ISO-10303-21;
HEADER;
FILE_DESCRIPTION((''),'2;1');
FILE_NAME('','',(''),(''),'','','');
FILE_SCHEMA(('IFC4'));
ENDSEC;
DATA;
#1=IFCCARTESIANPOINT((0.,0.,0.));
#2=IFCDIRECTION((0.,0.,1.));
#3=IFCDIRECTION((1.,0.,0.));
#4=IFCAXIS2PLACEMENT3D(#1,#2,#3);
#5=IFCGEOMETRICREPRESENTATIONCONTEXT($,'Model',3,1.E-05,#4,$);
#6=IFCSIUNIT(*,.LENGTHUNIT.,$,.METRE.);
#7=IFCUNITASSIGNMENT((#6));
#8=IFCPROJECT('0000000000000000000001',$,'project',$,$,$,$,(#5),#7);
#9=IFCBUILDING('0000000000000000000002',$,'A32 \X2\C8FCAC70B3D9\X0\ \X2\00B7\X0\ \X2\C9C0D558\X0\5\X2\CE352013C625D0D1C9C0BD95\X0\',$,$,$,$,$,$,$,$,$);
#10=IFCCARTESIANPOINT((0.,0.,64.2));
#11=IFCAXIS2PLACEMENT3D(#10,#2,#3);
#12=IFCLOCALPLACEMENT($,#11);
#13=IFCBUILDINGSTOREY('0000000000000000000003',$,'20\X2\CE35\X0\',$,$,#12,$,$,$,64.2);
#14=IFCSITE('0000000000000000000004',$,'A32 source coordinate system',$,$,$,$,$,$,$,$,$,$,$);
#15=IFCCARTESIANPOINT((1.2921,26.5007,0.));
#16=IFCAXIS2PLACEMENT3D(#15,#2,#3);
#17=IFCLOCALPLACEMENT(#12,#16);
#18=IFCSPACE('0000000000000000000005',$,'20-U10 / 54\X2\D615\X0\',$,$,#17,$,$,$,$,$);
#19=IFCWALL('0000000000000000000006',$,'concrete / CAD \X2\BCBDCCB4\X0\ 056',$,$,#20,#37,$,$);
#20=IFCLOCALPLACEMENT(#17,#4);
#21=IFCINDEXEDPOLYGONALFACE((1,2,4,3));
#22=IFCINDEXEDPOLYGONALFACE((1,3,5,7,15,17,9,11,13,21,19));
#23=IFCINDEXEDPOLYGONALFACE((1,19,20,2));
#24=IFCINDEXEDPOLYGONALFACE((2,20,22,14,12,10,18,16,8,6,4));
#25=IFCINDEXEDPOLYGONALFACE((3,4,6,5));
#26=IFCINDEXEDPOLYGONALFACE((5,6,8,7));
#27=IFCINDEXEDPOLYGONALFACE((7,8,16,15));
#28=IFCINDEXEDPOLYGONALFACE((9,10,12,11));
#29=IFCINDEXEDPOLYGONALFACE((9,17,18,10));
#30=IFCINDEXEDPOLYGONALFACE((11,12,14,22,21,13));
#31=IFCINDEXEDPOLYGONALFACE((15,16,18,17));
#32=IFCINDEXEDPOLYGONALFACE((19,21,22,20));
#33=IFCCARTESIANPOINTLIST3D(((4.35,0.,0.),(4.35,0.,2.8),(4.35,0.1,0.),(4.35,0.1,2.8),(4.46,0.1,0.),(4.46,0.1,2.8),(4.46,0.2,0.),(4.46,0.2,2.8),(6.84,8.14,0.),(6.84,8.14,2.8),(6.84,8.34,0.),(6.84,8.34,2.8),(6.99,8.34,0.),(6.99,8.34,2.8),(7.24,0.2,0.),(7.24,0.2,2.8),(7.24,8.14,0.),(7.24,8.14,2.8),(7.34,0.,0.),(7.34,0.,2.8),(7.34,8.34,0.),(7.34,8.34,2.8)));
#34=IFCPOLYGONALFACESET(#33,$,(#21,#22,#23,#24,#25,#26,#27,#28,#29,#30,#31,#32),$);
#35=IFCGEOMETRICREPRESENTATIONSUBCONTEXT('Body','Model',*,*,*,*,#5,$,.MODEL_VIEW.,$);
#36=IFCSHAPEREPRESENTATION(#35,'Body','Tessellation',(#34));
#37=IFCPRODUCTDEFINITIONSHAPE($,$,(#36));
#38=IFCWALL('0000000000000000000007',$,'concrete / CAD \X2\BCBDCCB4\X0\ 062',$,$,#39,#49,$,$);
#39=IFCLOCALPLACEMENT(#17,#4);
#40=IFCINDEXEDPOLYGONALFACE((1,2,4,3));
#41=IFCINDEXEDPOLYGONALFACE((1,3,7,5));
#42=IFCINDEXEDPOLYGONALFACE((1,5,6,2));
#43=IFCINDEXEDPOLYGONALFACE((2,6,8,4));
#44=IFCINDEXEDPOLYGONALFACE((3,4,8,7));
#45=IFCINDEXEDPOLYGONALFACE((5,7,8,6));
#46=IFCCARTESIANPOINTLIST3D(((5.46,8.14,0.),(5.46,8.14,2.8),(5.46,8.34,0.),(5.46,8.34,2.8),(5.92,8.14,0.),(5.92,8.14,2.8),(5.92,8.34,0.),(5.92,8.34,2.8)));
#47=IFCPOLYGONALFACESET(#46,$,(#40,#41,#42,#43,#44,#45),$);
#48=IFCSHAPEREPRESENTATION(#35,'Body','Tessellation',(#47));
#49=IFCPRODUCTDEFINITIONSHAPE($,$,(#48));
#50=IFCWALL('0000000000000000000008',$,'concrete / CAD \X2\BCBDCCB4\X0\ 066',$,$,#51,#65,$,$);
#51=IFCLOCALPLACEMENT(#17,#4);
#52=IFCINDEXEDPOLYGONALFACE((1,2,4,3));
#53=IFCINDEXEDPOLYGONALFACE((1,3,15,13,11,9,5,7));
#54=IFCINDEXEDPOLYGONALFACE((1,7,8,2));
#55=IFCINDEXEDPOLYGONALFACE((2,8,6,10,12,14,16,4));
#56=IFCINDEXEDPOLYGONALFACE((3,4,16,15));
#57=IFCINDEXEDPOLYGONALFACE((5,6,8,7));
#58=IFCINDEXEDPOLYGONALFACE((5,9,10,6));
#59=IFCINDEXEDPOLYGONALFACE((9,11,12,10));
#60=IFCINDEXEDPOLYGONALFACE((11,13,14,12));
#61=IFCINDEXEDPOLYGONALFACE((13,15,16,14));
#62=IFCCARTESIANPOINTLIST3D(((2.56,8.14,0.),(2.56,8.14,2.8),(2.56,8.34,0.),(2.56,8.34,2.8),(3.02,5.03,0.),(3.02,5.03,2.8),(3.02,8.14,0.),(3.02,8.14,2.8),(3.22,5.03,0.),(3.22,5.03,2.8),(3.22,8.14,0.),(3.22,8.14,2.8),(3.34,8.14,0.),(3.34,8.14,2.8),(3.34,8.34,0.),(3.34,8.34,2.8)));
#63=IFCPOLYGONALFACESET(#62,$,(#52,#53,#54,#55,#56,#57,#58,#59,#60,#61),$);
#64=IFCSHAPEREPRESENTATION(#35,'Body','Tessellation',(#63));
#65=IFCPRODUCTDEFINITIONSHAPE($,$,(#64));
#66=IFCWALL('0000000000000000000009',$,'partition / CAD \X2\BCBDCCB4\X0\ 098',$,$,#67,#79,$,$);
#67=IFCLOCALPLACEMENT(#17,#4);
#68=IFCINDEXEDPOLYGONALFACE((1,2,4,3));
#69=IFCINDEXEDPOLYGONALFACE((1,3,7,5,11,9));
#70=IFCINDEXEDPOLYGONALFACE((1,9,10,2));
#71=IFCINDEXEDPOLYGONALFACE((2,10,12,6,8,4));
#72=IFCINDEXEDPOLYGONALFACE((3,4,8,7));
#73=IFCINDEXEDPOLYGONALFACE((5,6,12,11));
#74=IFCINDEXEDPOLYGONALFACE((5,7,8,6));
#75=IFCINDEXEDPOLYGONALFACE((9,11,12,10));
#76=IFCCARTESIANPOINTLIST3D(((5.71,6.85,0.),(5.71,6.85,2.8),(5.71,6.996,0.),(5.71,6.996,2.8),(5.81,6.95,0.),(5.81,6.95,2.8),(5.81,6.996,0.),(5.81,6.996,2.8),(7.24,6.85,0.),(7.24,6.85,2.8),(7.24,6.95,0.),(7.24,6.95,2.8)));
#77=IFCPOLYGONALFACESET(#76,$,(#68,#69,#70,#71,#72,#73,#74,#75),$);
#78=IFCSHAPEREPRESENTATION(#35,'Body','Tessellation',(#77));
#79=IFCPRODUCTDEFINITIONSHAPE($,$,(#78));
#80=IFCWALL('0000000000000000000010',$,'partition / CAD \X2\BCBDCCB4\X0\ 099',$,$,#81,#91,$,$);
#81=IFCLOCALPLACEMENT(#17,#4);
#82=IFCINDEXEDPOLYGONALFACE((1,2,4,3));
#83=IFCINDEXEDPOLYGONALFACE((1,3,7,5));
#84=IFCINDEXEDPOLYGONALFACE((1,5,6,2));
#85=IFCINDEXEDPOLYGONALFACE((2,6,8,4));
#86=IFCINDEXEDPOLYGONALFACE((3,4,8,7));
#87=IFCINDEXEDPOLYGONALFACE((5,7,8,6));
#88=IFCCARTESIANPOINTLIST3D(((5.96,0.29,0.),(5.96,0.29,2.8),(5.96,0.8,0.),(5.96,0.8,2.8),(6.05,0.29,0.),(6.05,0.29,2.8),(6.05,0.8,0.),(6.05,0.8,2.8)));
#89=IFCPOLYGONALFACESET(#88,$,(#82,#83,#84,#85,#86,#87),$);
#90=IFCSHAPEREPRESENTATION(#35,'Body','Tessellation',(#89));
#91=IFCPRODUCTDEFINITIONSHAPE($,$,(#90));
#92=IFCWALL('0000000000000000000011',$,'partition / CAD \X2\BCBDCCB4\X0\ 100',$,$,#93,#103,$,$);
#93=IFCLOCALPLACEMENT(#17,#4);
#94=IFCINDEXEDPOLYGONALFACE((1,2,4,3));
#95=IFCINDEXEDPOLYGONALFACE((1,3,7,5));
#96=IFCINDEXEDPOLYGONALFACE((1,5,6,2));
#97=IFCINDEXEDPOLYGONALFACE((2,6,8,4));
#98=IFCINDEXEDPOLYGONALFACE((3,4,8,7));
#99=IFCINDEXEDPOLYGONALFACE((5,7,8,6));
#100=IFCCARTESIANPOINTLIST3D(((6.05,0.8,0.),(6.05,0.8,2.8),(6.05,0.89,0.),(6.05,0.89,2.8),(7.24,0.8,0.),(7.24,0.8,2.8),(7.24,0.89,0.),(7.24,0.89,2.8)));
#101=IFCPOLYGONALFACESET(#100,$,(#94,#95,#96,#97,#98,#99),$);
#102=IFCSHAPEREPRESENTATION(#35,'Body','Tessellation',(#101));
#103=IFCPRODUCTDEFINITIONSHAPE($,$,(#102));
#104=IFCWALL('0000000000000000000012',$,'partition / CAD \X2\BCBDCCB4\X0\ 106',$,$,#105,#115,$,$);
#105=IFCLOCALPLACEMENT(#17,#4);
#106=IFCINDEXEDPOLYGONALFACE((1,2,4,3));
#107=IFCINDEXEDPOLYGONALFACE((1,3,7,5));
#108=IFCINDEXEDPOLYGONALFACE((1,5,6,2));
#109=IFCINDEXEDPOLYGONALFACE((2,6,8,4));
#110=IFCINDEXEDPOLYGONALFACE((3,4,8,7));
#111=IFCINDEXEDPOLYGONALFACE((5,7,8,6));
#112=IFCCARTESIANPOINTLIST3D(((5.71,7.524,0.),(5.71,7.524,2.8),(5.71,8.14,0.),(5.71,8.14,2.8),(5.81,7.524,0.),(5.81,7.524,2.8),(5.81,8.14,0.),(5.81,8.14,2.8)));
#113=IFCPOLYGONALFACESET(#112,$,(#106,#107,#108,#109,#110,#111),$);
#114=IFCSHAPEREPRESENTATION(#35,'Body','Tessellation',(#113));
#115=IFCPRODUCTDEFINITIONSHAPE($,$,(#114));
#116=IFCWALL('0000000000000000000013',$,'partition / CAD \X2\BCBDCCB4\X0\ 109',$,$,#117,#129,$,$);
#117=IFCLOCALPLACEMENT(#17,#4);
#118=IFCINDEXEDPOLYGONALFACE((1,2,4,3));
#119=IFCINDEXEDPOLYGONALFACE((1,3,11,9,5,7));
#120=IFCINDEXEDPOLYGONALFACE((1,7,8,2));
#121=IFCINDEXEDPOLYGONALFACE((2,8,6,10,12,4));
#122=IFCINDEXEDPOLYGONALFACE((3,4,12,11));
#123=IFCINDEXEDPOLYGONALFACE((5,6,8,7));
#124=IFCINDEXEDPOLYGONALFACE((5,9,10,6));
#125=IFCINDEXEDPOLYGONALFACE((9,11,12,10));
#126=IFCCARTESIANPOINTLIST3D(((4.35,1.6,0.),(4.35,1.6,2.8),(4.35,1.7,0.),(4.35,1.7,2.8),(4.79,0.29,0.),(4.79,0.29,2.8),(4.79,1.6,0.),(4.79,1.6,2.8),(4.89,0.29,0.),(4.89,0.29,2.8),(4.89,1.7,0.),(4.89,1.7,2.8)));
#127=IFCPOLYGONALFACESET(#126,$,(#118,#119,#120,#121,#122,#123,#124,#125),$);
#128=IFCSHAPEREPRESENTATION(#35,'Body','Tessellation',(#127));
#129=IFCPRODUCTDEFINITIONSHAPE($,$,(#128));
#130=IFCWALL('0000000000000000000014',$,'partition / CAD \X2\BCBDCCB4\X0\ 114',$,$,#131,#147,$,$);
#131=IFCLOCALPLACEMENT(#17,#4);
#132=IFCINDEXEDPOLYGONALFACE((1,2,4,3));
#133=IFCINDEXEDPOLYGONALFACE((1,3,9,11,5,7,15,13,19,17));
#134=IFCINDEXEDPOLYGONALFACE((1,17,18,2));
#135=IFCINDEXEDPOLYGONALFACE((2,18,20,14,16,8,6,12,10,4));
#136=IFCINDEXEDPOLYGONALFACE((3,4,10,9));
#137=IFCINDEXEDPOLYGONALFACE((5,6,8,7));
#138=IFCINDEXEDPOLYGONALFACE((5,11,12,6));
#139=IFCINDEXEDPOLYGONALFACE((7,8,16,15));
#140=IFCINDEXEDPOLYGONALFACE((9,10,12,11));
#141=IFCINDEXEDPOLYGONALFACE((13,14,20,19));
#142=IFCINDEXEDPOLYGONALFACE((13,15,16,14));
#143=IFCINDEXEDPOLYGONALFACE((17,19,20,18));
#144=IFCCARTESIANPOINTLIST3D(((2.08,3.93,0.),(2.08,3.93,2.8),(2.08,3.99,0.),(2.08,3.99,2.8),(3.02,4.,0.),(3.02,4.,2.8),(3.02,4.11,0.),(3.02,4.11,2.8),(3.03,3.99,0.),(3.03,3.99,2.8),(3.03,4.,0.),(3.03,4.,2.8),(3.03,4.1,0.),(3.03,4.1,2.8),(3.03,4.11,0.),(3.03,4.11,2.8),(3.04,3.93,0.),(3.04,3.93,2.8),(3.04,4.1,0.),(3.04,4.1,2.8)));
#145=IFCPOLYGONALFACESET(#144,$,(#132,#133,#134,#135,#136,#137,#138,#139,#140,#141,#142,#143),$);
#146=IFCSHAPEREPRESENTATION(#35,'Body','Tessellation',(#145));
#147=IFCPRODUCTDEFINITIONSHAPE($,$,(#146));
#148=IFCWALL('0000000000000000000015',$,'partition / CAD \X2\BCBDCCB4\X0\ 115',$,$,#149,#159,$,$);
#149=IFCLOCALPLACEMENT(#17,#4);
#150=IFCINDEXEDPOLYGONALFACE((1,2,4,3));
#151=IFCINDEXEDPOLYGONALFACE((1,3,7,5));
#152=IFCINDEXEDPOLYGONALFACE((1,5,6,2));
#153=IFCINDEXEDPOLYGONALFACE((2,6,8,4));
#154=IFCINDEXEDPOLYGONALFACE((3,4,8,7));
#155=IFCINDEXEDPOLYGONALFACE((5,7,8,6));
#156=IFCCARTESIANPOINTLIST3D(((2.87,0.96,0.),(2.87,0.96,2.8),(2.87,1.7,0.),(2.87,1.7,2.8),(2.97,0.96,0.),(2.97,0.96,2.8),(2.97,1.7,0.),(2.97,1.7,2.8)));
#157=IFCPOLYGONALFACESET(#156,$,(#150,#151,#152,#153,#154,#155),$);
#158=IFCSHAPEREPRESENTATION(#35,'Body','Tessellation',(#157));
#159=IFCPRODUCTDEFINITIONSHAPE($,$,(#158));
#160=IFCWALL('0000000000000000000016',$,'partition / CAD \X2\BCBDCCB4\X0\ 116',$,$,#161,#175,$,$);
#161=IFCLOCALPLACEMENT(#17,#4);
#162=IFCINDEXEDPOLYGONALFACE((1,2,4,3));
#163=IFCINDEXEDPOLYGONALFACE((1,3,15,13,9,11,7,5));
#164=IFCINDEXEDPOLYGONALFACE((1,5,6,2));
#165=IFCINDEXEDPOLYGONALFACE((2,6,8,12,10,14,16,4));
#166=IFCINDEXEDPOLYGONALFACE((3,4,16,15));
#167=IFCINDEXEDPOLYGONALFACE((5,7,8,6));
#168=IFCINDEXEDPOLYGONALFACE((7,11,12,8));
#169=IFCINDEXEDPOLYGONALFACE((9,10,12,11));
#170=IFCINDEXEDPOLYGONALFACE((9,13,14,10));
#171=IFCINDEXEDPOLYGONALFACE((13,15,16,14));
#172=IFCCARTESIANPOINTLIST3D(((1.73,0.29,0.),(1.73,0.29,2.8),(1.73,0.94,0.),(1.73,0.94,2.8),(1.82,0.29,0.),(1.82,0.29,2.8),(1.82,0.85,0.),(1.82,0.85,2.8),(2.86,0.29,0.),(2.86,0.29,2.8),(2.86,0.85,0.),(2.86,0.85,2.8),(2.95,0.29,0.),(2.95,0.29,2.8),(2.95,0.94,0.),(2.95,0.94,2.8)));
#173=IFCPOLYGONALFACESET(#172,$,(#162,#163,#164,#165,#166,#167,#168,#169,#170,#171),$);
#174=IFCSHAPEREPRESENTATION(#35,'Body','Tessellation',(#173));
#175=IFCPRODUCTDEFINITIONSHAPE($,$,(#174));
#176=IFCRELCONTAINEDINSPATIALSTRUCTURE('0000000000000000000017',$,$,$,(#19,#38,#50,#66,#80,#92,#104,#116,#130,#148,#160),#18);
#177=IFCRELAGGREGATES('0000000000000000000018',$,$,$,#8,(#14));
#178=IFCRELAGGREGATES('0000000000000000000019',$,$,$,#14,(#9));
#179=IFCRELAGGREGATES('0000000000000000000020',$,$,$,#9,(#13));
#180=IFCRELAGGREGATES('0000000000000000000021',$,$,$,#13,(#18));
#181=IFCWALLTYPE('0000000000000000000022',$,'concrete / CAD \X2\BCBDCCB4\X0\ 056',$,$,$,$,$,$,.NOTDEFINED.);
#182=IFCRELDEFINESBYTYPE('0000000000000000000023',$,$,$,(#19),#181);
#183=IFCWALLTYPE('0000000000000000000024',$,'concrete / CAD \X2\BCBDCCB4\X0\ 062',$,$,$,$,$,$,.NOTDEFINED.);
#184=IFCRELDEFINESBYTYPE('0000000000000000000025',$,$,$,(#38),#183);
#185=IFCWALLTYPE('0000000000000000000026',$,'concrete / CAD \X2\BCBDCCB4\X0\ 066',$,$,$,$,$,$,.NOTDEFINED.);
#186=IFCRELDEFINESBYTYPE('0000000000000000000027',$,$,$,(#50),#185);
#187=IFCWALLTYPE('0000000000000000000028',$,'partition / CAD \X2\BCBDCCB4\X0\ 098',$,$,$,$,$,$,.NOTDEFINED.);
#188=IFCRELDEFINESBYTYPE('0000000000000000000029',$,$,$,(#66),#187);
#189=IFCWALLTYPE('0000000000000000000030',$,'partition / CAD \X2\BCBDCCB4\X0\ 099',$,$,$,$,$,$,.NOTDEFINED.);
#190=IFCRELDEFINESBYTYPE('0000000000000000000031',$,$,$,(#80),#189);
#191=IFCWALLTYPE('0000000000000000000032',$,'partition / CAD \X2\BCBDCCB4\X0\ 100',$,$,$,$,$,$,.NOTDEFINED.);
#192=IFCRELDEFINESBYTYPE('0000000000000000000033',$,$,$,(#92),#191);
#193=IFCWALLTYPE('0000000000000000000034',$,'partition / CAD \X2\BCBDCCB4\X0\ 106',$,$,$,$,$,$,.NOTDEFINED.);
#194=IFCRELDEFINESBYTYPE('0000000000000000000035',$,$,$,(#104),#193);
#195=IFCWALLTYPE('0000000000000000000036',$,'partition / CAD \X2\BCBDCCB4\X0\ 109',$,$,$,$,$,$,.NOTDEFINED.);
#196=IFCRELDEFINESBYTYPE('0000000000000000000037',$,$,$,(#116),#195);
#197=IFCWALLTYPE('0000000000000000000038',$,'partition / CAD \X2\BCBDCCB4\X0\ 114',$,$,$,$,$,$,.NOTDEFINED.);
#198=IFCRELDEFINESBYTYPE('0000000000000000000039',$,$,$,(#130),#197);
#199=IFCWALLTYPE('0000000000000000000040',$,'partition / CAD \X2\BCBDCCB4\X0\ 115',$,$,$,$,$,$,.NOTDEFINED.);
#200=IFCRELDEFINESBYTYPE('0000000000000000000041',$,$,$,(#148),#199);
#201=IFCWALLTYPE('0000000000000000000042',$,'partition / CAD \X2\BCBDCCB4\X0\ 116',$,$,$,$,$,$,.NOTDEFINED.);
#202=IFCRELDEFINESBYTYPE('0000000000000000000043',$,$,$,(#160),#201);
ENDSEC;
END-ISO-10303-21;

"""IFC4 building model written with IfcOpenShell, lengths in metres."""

from ifc_helpers import new_model, si_unit, frame, origin, origin_with_axes, place, context, subcontext, project, spatial, polyline, outline, extrude, source, transform, mapped, type_object, type_shapes, element, save


model = new_model("IFC4")

# Units and contexts
model_context = context("Model", 3, precision=1e-05, world=origin_with_axes())
body_context = subcontext(model_context, "Body", "Model", "MODEL_VIEW")
ifc_project = project(units=[si_unit("LENGTHUNIT", "METRE")], contexts=[model_context])

# Site, building, storey, space
site = spatial("IfcSite", under=ifc_project, Name="A32 source coordinate system")
building = spatial("IfcBuilding", under=site, Name="A32 주거동 · 지하5층–옥탑지붕")
storey_placement = place(None, frame((0.0, 0.0, 64.2), z_axis=(0.0, 0.0, 1.0), x_axis=(1.0, 0.0, 0.0)))
storey = spatial("IfcBuildingStorey", under=building, at=storey_placement, Name="20층", Elevation=64.2)
space_placement = place(storey_placement, frame((1.2921, 26.5007, 0.0), z_axis=(0.0, 0.0, 1.0), x_axis=(1.0, 0.0, 0.0)))
space = spatial("IfcSpace", under=storey, at=space_placement, Name="20-U10 / 54형")

# Walls
wall_type_1 = type_object("IfcWallType", Name="concrete / CAD 벽체 056", PredefinedType="NOTDEFINED")
shared_shape_1 = source(origin(), body_context, "Body", "SweptSolid", [
    extrude(outline(polyline([(7.24, 0.2), (7.24, 8.14), (6.84, 8.14), (6.84, 8.34), (6.99, 8.34), (6.99, 8.34), (7.34, 8.34), (7.34, 0.0), (4.35, 0.0), (4.35, 0.1), (4.46, 0.1), (4.46, 0.2), (7.24, 0.2)])), origin(), (0.0, 0.0, 1.0), 2.8),
])
type_shapes(wall_type_1, [shared_shape_1])
wall_1_placement = place(space_placement, origin_with_axes())
element("IfcWall", 1, at=wall_1_placement, inside=space, type_object=wall_type_1, Name="concrete / CAD 벽체 056", context=body_context, shape_type="MappedRepresentation", body=[
    mapped(shared_shape_1, transform((0.0, 0.0, 0.0), scale=1.0)),
])
wall_type_2 = type_object("IfcWallType", Name="concrete / CAD 벽체 062", PredefinedType="NOTDEFINED")
shared_shape_2 = source(origin(), body_context, "Body", "SweptSolid", [
    extrude(outline(polyline([(5.46, 8.14), (5.46, 8.34), (5.92, 8.34), (5.92, 8.14), (5.46, 8.14)])), origin(), (0.0, 0.0, 1.0), 2.8),
])
type_shapes(wall_type_2, [shared_shape_2])
wall_2_placement = place(space_placement, origin_with_axes())
element("IfcWall", 2, at=wall_2_placement, inside=space, type_object=wall_type_2, Name="concrete / CAD 벽체 062", context=body_context, shape_type="MappedRepresentation", body=[
    mapped(shared_shape_2, transform((0.0, 0.0, 0.0), scale=1.0)),
])
wall_type_3 = type_object("IfcWallType", Name="concrete / CAD 벽체 066", PredefinedType="NOTDEFINED")
shared_shape_3 = source(origin(), body_context, "Body", "SweptSolid", [
    extrude(outline(polyline([(3.22, 8.14), (3.22, 5.03), (3.02, 5.03), (3.02, 8.14), (2.56, 8.14), (2.56, 8.34), (3.34, 8.34), (3.34, 8.14), (3.22, 8.14)])), origin(), (0.0, 0.0, 1.0), 2.8),
])
type_shapes(wall_type_3, [shared_shape_3])
wall_3_placement = place(space_placement, origin_with_axes())
element("IfcWall", 3, at=wall_3_placement, inside=space, type_object=wall_type_3, Name="concrete / CAD 벽체 066", context=body_context, shape_type="MappedRepresentation", body=[
    mapped(shared_shape_3, transform((0.0, 0.0, 0.0), scale=1.0)),
])
wall_type_4 = type_object("IfcWallType", Name="partition / CAD 벽체 098", PredefinedType="NOTDEFINED")
shared_shape_4 = source(origin(), body_context, "Body", "SweptSolid", [
    extrude(outline(polyline([(5.71, 6.996), (5.81, 6.996), (5.81, 6.95), (7.24, 6.95), (7.24, 6.85), (5.71, 6.85), (5.71, 6.996)])), origin(), (0.0, 0.0, 1.0), 2.8),
])
type_shapes(wall_type_4, [shared_shape_4])
wall_4_placement = place(space_placement, origin_with_axes())
element("IfcWall", 4, at=wall_4_placement, inside=space, type_object=wall_type_4, Name="partition / CAD 벽체 098", context=body_context, shape_type="MappedRepresentation", body=[
    mapped(shared_shape_4, transform((0.0, 0.0, 0.0), scale=1.0)),
])
wall_type_5 = type_object("IfcWallType", Name="partition / CAD 벽체 099", PredefinedType="NOTDEFINED")
shared_shape_5 = source(origin(), body_context, "Body", "SweptSolid", [
    extrude(outline(polyline([(6.05, 0.8), (6.05, 0.29), (5.96, 0.29), (5.96, 0.8), (6.05, 0.8)])), origin(), (0.0, 0.0, 1.0), 2.8),
])
type_shapes(wall_type_5, [shared_shape_5])
wall_5_placement = place(space_placement, origin_with_axes())
element("IfcWall", 5, at=wall_5_placement, inside=space, type_object=wall_type_5, Name="partition / CAD 벽체 099", context=body_context, shape_type="MappedRepresentation", body=[
    mapped(shared_shape_5, transform((0.0, 0.0, 0.0), scale=1.0)),
])
wall_type_6 = type_object("IfcWallType", Name="partition / CAD 벽체 100", PredefinedType="NOTDEFINED")
shared_shape_6 = source(origin(), body_context, "Body", "SweptSolid", [
    extrude(outline(polyline([(7.24, 0.8), (6.05, 0.8), (6.05, 0.89), (7.24, 0.89), (7.24, 0.8)])), origin(), (0.0, 0.0, 1.0), 2.8),
])
type_shapes(wall_type_6, [shared_shape_6])
wall_6_placement = place(space_placement, origin_with_axes())
element("IfcWall", 6, at=wall_6_placement, inside=space, type_object=wall_type_6, Name="partition / CAD 벽체 100", context=body_context, shape_type="MappedRepresentation", body=[
    mapped(shared_shape_6, transform((0.0, 0.0, 0.0), scale=1.0)),
])
wall_type_7 = type_object("IfcWallType", Name="partition / CAD 벽체 106", PredefinedType="NOTDEFINED")
shared_shape_7 = source(origin(), body_context, "Body", "SweptSolid", [
    extrude(outline(polyline([(5.71, 8.14), (5.81, 8.14), (5.81, 7.524), (5.71, 7.524), (5.71, 8.14)])), origin(), (0.0, 0.0, 1.0), 2.8),
])
type_shapes(wall_type_7, [shared_shape_7])
wall_7_placement = place(space_placement, origin_with_axes())
element("IfcWall", 7, at=wall_7_placement, inside=space, type_object=wall_type_7, Name="partition / CAD 벽체 106", context=body_context, shape_type="MappedRepresentation", body=[
    mapped(shared_shape_7, transform((0.0, 0.0, 0.0), scale=1.0)),
])
wall_type_8 = type_object("IfcWallType", Name="partition / CAD 벽체 109", PredefinedType="NOTDEFINED")
shared_shape_8 = source(origin(), body_context, "Body", "SweptSolid", [
    extrude(outline(polyline([(4.79, 1.6), (4.35, 1.6), (4.35, 1.7), (4.89, 1.7), (4.89, 0.29), (4.79, 0.29), (4.79, 1.6)])), origin(), (0.0, 0.0, 1.0), 2.8),
])
type_shapes(wall_type_8, [shared_shape_8])
wall_8_placement = place(space_placement, origin_with_axes())
element("IfcWall", 8, at=wall_8_placement, inside=space, type_object=wall_type_8, Name="partition / CAD 벽체 109", context=body_context, shape_type="MappedRepresentation", body=[
    mapped(shared_shape_8, transform((0.0, 0.0, 0.0), scale=1.0)),
])
wall_type_9 = type_object("IfcWallType", Name="partition / CAD 벽체 114", PredefinedType="NOTDEFINED")
shared_shape_9 = source(origin(), body_context, "Body", "SweptSolid", [
    extrude(outline(polyline([(2.08, 3.99), (3.03, 3.99), (3.03, 4.0), (3.02, 4.0), (3.02, 4.11), (3.03, 4.11), (3.03, 4.1), (3.04, 4.1), (3.04, 3.93), (2.08, 3.93), (2.08, 3.99)])), origin(), (0.0, 0.0, 1.0), 2.8),
])
type_shapes(wall_type_9, [shared_shape_9])
wall_9_placement = place(space_placement, origin_with_axes())
element("IfcWall", 9, at=wall_9_placement, inside=space, type_object=wall_type_9, Name="partition / CAD 벽체 114", context=body_context, shape_type="MappedRepresentation", body=[
    mapped(shared_shape_9, transform((0.0, 0.0, 0.0), scale=1.0)),
])
wall_type_10 = type_object("IfcWallType", Name="partition / CAD 벽체 115", PredefinedType="NOTDEFINED")
shared_shape_10 = source(origin(), body_context, "Body", "SweptSolid", [
    extrude(outline(polyline([(2.87, 1.7), (2.97, 1.7), (2.97, 0.96), (2.87, 0.96), (2.87, 1.7)])), origin(), (0.0, 0.0, 1.0), 2.8),
])
type_shapes(wall_type_10, [shared_shape_10])
wall_10_placement = place(space_placement, origin_with_axes())
element("IfcWall", 10, at=wall_10_placement, inside=space, type_object=wall_type_10, Name="partition / CAD 벽체 115", context=body_context, shape_type="MappedRepresentation", body=[
    mapped(shared_shape_10, transform((0.0, 0.0, 0.0), scale=1.0)),
])
wall_type_11 = type_object("IfcWallType", Name="partition / CAD 벽체 116", PredefinedType="NOTDEFINED")
shared_shape_11 = source(origin(), body_context, "Body", "SweptSolid", [
    extrude(outline(polyline([(2.95, 0.29), (2.86, 0.29), (2.86, 0.85), (1.82, 0.85), (1.82, 0.29), (1.73, 0.29), (1.73, 0.94), (2.95, 0.94), (2.95, 0.29)])), origin(), (0.0, 0.0, 1.0), 2.8),
])
type_shapes(wall_type_11, [shared_shape_11])
wall_11_placement = place(space_placement, origin_with_axes())
element("IfcWall", 11, at=wall_11_placement, inside=space, type_object=wall_type_11, Name="partition / CAD 벽체 116", context=body_context, shape_type="MappedRepresentation", body=[
    mapped(shared_shape_11, transform((0.0, 0.0, 0.0), scale=1.0)),
])

save(model, "model.ifc")
